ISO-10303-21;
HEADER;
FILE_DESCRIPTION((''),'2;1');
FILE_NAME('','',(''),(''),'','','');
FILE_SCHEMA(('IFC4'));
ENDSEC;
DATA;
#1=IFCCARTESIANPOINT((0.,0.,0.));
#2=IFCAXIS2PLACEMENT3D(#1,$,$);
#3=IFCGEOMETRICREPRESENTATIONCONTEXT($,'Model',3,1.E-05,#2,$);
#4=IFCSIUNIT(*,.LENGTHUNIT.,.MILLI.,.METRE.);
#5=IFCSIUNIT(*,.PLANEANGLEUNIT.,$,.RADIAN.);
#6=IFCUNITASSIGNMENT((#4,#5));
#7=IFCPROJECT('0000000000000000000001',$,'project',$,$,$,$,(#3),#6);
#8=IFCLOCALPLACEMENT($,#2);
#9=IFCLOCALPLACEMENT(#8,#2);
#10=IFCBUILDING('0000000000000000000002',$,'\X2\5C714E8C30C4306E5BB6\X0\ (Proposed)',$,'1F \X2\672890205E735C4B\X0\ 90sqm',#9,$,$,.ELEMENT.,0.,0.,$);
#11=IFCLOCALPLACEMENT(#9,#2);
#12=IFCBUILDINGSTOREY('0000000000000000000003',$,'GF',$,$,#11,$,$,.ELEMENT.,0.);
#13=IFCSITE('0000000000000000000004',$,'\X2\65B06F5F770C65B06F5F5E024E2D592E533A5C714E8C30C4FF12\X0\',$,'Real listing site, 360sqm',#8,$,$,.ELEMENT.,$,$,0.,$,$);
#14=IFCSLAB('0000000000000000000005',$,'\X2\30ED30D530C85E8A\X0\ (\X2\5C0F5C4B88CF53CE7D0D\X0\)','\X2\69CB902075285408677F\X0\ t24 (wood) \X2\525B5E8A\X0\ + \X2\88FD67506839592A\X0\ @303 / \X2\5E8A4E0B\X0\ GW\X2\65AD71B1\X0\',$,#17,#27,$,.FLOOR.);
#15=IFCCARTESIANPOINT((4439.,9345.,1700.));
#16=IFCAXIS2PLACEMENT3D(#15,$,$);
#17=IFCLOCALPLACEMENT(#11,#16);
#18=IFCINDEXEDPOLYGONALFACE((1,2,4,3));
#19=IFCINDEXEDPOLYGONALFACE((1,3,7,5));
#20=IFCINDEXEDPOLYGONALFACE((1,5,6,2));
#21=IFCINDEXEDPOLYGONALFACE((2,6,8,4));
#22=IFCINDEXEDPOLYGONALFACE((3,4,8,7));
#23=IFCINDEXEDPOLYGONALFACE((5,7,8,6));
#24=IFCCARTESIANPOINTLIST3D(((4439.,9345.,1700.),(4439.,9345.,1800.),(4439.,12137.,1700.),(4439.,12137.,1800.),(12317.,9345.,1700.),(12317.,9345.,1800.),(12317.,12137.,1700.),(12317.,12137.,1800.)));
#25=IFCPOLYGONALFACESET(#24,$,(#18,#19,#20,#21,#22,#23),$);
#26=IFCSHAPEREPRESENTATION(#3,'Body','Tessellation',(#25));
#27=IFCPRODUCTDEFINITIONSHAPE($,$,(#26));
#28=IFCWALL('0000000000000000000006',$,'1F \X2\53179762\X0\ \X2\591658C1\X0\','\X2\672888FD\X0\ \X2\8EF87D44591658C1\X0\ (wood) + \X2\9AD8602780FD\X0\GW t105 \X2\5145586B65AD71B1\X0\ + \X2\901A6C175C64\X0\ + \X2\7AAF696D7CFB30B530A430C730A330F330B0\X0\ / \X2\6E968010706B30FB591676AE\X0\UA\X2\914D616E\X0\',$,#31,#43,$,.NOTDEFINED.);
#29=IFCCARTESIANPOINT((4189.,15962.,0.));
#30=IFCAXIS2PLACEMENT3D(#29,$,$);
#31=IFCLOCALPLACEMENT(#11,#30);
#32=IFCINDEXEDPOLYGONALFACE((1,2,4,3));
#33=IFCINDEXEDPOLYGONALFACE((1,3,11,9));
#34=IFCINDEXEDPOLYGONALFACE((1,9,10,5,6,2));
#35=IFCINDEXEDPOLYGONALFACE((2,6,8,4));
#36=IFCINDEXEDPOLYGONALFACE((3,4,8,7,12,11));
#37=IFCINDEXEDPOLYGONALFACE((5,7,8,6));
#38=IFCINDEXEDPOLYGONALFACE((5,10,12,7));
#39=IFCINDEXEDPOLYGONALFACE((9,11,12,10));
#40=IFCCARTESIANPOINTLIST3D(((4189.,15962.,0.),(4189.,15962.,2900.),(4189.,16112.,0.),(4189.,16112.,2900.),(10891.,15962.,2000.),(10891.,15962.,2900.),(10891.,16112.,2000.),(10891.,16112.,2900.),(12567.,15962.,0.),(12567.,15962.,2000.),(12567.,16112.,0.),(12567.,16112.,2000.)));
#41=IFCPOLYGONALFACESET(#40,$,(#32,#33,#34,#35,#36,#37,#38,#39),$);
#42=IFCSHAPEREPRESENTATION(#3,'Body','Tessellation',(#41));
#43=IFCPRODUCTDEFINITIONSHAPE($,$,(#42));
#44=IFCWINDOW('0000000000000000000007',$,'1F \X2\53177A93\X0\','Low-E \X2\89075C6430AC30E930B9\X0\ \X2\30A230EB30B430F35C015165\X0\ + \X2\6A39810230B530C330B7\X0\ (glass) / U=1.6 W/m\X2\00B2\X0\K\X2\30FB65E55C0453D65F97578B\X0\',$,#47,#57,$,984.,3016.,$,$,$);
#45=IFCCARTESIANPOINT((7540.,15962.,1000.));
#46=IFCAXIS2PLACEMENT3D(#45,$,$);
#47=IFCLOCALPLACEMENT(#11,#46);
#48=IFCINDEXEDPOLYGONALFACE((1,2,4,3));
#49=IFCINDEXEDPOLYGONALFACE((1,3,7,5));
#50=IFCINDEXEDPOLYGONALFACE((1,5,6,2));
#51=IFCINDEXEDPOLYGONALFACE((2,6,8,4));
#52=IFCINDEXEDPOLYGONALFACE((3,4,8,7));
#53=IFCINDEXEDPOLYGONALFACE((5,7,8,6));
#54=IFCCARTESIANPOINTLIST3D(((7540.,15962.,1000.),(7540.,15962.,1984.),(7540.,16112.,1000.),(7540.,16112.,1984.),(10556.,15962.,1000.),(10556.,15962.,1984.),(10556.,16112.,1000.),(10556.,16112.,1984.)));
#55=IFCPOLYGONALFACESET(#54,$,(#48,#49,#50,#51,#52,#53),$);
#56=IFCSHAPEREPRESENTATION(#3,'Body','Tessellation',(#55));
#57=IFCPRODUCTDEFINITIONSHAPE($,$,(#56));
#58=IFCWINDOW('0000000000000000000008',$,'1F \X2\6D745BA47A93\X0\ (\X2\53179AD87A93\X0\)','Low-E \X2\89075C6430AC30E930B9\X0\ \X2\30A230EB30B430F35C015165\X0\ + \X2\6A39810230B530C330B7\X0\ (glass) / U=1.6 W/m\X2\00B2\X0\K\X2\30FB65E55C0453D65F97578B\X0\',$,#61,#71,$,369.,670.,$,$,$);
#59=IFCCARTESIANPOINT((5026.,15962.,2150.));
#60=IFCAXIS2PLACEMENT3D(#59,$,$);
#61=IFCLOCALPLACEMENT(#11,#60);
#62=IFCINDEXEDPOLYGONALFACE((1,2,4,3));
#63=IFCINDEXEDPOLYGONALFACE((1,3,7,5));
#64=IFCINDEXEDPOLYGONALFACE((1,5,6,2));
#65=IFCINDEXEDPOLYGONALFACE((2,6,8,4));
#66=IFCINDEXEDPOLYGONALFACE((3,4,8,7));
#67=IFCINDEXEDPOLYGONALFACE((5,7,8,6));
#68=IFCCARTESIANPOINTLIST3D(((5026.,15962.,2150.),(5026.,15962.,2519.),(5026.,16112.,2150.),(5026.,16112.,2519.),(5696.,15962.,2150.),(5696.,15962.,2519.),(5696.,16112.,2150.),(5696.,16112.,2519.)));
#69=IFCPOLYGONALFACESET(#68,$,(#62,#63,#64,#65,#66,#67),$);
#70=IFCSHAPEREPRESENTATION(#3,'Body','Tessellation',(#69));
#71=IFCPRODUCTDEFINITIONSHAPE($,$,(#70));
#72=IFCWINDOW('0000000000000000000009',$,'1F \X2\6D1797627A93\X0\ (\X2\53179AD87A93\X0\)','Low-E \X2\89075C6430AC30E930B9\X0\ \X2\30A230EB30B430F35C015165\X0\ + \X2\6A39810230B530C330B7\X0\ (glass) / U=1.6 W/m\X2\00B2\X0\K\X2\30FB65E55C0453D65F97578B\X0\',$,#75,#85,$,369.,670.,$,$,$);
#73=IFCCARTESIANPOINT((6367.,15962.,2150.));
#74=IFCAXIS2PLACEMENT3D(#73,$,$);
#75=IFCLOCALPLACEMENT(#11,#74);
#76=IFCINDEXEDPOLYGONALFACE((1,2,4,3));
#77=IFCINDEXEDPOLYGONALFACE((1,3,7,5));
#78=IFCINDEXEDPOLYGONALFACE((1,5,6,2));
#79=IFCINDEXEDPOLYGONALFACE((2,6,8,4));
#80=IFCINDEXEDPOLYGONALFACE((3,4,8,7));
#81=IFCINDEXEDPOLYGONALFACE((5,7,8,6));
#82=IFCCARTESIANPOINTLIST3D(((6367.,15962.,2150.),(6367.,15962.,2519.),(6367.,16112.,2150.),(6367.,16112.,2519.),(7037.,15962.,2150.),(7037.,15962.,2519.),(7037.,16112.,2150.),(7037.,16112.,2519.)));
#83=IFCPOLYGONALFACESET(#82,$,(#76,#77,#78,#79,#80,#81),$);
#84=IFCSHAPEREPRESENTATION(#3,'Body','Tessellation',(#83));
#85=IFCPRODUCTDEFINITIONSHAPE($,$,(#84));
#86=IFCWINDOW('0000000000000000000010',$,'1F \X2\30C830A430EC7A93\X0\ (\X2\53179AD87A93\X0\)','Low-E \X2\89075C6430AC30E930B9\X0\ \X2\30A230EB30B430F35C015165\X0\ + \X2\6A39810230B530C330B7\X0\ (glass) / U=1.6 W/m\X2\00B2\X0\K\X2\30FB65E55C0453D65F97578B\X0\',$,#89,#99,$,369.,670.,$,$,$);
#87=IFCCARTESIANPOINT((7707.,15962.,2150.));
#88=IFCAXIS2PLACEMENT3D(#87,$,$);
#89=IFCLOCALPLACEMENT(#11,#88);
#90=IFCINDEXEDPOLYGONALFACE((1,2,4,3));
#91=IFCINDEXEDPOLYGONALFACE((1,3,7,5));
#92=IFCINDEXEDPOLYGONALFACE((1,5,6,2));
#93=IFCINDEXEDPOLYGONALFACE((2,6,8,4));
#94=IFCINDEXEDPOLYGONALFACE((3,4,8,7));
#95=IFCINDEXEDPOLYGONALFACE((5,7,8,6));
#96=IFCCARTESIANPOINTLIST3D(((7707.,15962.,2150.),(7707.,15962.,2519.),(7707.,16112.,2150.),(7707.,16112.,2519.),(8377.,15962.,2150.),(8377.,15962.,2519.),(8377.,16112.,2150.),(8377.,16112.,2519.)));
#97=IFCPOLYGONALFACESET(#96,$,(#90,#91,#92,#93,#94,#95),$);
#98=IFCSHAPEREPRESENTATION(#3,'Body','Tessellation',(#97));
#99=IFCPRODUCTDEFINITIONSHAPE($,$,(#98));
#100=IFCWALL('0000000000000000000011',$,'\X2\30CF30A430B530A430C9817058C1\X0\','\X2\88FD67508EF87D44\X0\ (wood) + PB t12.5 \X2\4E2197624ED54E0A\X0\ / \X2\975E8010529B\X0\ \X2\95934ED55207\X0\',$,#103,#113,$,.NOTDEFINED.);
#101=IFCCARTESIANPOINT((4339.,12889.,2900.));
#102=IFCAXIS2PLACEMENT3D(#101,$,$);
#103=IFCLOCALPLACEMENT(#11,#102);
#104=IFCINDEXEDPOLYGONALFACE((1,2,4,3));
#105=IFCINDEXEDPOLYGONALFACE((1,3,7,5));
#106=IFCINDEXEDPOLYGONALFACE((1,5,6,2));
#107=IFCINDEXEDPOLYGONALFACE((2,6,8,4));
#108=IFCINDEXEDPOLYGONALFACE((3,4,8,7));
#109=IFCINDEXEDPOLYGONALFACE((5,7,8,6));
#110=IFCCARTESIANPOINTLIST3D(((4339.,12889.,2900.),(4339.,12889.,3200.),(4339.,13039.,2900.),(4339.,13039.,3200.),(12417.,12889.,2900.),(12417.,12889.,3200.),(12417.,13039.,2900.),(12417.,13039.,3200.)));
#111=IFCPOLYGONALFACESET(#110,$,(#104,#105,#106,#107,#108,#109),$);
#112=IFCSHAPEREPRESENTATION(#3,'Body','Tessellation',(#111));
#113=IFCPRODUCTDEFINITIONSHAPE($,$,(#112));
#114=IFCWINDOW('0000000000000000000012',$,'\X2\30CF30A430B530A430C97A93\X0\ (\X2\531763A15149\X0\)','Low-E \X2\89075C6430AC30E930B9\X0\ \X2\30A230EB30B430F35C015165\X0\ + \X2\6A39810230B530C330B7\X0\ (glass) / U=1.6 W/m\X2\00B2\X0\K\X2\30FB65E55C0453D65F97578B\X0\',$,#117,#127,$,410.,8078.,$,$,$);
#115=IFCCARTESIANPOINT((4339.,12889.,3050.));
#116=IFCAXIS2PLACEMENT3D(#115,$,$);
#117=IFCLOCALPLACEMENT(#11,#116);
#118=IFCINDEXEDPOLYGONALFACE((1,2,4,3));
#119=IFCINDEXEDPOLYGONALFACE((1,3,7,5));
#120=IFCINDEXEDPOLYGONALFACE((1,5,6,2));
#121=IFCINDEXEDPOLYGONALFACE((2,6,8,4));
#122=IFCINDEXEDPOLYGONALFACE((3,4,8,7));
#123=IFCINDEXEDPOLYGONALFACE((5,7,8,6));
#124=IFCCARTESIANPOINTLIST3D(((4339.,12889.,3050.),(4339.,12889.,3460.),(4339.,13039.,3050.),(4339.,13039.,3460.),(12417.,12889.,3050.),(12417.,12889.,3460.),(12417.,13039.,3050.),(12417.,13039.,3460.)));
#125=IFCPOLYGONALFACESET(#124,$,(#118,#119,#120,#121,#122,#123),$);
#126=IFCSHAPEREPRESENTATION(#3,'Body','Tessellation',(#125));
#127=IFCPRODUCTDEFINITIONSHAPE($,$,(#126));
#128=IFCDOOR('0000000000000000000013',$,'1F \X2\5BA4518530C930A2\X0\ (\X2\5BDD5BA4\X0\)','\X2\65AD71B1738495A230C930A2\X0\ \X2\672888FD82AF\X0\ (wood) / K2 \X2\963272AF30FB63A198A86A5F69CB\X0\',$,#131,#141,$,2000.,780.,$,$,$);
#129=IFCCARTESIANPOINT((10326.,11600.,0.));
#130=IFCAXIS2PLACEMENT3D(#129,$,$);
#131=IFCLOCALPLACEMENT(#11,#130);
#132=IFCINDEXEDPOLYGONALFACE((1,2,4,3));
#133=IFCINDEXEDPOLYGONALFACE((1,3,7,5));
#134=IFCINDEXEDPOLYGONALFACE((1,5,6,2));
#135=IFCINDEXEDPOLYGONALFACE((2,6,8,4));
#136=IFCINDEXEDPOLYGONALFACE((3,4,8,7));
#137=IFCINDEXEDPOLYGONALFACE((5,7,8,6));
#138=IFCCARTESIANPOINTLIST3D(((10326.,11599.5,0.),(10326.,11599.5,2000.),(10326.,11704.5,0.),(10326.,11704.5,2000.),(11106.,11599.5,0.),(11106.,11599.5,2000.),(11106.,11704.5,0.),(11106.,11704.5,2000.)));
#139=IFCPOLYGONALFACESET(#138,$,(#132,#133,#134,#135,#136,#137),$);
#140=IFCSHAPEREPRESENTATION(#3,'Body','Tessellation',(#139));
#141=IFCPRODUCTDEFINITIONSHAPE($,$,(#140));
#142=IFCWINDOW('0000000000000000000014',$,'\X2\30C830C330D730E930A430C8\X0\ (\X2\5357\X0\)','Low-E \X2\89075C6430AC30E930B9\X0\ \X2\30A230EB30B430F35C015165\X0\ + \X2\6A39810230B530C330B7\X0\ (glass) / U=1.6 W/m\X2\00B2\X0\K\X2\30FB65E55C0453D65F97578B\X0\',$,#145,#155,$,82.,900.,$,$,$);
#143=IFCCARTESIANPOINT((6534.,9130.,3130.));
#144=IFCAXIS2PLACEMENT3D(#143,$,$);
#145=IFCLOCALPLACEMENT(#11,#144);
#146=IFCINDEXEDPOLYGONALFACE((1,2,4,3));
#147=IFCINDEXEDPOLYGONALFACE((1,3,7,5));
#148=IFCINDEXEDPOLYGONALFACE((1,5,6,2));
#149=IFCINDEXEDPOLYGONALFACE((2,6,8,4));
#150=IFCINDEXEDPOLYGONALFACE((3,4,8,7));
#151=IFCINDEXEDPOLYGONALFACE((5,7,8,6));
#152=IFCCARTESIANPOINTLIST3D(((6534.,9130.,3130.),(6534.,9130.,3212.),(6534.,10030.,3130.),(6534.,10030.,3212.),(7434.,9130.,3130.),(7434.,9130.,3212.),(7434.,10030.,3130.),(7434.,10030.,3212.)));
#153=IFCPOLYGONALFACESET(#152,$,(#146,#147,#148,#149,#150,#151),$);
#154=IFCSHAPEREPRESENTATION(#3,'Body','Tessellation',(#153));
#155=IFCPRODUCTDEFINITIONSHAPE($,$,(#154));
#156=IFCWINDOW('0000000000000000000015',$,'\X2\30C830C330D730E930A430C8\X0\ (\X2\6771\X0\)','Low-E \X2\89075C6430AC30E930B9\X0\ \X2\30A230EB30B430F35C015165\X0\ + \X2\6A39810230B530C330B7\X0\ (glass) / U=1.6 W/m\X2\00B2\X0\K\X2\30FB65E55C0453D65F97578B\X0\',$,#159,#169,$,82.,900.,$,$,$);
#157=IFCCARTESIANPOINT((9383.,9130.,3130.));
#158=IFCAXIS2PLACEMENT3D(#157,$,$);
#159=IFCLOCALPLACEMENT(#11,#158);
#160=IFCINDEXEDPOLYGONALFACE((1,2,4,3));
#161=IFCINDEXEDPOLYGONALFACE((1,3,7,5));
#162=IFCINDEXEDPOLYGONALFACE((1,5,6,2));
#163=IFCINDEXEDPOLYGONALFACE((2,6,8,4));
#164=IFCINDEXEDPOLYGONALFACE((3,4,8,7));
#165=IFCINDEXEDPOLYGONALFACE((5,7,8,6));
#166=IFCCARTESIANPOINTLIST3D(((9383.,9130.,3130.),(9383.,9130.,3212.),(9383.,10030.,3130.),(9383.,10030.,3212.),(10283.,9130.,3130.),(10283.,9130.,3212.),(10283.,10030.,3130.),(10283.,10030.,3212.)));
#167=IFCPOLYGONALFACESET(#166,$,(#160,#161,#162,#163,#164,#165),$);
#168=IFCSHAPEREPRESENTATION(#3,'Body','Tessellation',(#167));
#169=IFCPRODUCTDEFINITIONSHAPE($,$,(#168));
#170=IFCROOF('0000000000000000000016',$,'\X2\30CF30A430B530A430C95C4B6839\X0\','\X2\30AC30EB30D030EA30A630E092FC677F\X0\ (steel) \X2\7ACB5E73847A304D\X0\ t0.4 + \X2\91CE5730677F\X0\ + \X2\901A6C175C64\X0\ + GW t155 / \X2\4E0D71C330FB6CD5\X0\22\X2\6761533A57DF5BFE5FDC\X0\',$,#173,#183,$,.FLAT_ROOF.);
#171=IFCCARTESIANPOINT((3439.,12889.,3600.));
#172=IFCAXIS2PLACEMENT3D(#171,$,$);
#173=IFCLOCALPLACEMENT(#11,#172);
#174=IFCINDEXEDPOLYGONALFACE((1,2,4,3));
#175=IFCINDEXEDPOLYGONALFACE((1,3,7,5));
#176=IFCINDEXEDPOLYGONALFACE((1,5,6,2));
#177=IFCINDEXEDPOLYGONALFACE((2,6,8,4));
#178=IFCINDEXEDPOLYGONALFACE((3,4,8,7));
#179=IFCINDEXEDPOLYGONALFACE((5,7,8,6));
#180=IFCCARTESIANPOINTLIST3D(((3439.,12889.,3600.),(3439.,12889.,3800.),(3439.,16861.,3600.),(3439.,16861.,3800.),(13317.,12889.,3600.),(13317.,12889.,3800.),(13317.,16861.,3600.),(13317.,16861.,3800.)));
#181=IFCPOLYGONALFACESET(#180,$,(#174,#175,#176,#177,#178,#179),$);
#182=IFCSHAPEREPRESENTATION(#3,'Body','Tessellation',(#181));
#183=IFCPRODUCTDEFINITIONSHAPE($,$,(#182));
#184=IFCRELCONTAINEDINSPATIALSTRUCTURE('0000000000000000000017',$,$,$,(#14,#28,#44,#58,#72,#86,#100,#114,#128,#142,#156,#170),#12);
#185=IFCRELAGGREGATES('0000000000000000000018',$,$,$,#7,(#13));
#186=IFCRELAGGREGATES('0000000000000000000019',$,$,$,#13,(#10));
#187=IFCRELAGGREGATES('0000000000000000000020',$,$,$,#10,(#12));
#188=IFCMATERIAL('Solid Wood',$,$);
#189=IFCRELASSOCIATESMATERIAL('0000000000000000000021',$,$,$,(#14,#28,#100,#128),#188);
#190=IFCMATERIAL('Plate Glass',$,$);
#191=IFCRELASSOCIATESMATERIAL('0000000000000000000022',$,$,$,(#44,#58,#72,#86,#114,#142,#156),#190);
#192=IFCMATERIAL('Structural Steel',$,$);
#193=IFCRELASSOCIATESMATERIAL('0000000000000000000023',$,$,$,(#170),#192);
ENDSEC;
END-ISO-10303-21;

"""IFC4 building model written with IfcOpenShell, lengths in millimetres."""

from ifc_helpers import new_model, si_unit, frame, frame_2d, origin, place, context, project, spatial, rectangle, extrude, material, element, fill, save


model = new_model("IFC4")

# Units and contexts
model_context = context("Model", 3, precision=1e-05, world=origin())
ifc_project = project(units=[si_unit("LENGTHUNIT", "METRE", prefix="MILLI"), si_unit("PLANEANGLEUNIT", "RADIAN")], contexts=[model_context])

# Site, building, storey
site_placement = place(None, origin())
site = spatial("IfcSite", under=ifc_project, at=site_placement, Name="新潟県新潟市中央区山二ツ２", ObjectType="Real listing site, 360sqm", CompositionType="ELEMENT", RefElevation=0.0)
building_placement = place(site_placement, origin())
building = spatial("IfcBuilding", under=site, at=building_placement, Name="山二ツの家 (Proposed)", ObjectType="1F 木造平屋 90sqm", CompositionType="ELEMENT", ElevationOfRefHeight=0.0, ElevationOfTerrain=0.0)
storey_placement = place(building_placement, origin())
storey = spatial("IfcBuildingStorey", under=building, at=storey_placement, Name="GF", CompositionType="ELEMENT", Elevation=0.0)

# Slab
ifc_material_1 = material(Name="Solid Wood")
slab_placement = place(storey_placement, frame((4439.0, 9345.0, 1700.0)))
element("IfcSlab", 1, at=slab_placement, inside=storey, material=ifc_material_1, Name="ロフト床 (小屋裏収納)", Description="構造用合板 t24 (wood) 剛床 + 製材根太 @303 / 床下 GW断熱", PredefinedType="FLOOR", context=model_context, shape_type="SweptSolid", body=[
    extrude(rectangle(XDim=7878.0, YDim=2792.0, at=frame_2d((3939.0, 1396.0))), frame((4439.0, 9345.0, 1700.0)), (0.0, 0.0, 1.0), 100.0),
])

# Wall, openings, windows
wall_1_placement = place(storey_placement, frame((4189.0, 15962.0, 0.0)))
wall_1 = element("IfcWall", 2, at=wall_1_placement, inside=storey, material=ifc_material_1, Name="1F 北面 外壁", Description="木製 軸組外壁 (wood) + 高性能GW t105 充填断熱 + 通気層 + 窯業系サイディング / 準耐火・外皮UA配慮", PredefinedType="NOTDEFINED", context=model_context, shape_type="SweptSolid", body=[
    extrude(rectangle(XDim=8378.0, YDim=150.0, at=frame_2d((4189.0, 75.0))), frame((4189.0, 15962.0, 0.0)), (0.0, 0.0, 1.0), 2900.0),
])
opening_1_placement = place(storey_placement, frame((7540.0, 15962.0, 1000.0)))
opening_1 = element("IfcOpeningElement", 3, at=opening_1_placement, cuts=wall_1, PredefinedType="NOTDEFINED", context=model_context, shape_type="SweptSolid", body=[
    extrude(rectangle(XDim=3016.0, YDim=150.0, at=frame_2d((1508.0, 75.0))), frame((7540.0, 15962.0, 1000.0)), (0.0, 0.0, 1.0), 984.0),
])
opening_2_placement = place(storey_placement, frame((5026.0, 15962.0, 2150.0)))
opening_2 = element("IfcOpeningElement", 4, at=opening_2_placement, cuts=wall_1, PredefinedType="NOTDEFINED", context=model_context, shape_type="SweptSolid", body=[
    extrude(rectangle(XDim=670.0, YDim=150.0, at=frame_2d((335.0, 75.0))), frame((5026.0, 15962.0, 2150.0)), (0.0, 0.0, 1.0), 369.0),
])
opening_3_placement = place(storey_placement, frame((6367.0, 15962.0, 2150.0)))
opening_3 = element("IfcOpeningElement", 5, at=opening_3_placement, cuts=wall_1, PredefinedType="NOTDEFINED", context=model_context, shape_type="SweptSolid", body=[
    extrude(rectangle(XDim=670.0, YDim=150.0, at=frame_2d((335.0, 75.0))), frame((6367.0, 15962.0, 2150.0)), (0.0, 0.0, 1.0), 369.0),
])
opening_4_placement = place(storey_placement, frame((7707.0, 15962.0, 2150.0)))
opening_4 = element("IfcOpeningElement", 6, at=opening_4_placement, cuts=wall_1, PredefinedType="NOTDEFINED", context=model_context, shape_type="SweptSolid", body=[
    extrude(rectangle(XDim=670.0, YDim=150.0, at=frame_2d((335.0, 75.0))), frame((7707.0, 15962.0, 2150.0)), (0.0, 0.0, 1.0), 369.0),
])
ifc_material_2 = material(Name="Plate Glass")
window_1_placement = place(storey_placement, frame((7540.0, 15962.0, 1000.0)))
window_1 = element("IfcWindow", 7, at=window_1_placement, inside=storey, material=ifc_material_2, Name="1F 北窓", Description="Low-E 複層ガラス アルゴン封入 + 樹脂サッシ (glass) / U=1.6 W/m²K・日射取得型", OverallHeight=984.0, OverallWidth=3016.0, context=model_context, shape_type="SweptSolid", body=[
    extrude(rectangle(XDim=3016.0, YDim=150.0, at=frame_2d((1508.0, 75.0))), frame((7540.0, 15962.0, 1000.0)), (0.0, 0.0, 1.0), 984.0),
])
fill(opening_1, window_1)
window_2_placement = place(storey_placement, frame((5026.0, 15962.0, 2150.0)))
window_2 = element("IfcWindow", 8, at=window_2_placement, inside=storey, material=ifc_material_2, Name="1F 浴室窓 (北高窓)", Description="Low-E 複層ガラス アルゴン封入 + 樹脂サッシ (glass) / U=1.6 W/m²K・日射取得型", OverallHeight=369.0, OverallWidth=670.0, context=model_context, shape_type="SweptSolid", body=[
    extrude(rectangle(XDim=670.0, YDim=150.0, at=frame_2d((335.0, 75.0))), frame((5026.0, 15962.0, 2150.0)), (0.0, 0.0, 1.0), 369.0),
])
fill(opening_2, window_2)
window_3_placement = place(storey_placement, frame((6367.0, 15962.0, 2150.0)))
window_3 = element("IfcWindow", 9, at=window_3_placement, inside=storey, material=ifc_material_2, Name="1F 洗面窓 (北高窓)", Description="Low-E 複層ガラス アルゴン封入 + 樹脂サッシ (glass) / U=1.6 W/m²K・日射取得型", OverallHeight=369.0, OverallWidth=670.0, context=model_context, shape_type="SweptSolid", body=[
    extrude(rectangle(XDim=670.0, YDim=150.0, at=frame_2d((335.0, 75.0))), frame((6367.0, 15962.0, 2150.0)), (0.0, 0.0, 1.0), 369.0),
])
fill(opening_3, window_3)
window_4_placement = place(storey_placement, frame((7707.0, 15962.0, 2150.0)))
window_4 = element("IfcWindow", 10, at=window_4_placement, inside=storey, material=ifc_material_2, Name="1F トイレ窓 (北高窓)", Description="Low-E 複層ガラス アルゴン封入 + 樹脂サッシ (glass) / U=1.6 W/m²K・日射取得型", OverallHeight=369.0, OverallWidth=670.0, context=model_context, shape_type="SweptSolid", body=[
    extrude(rectangle(XDim=670.0, YDim=150.0, at=frame_2d((335.0, 75.0))), frame((7707.0, 15962.0, 2150.0)), (0.0, 0.0, 1.0), 369.0),
])
fill(opening_4, window_4)

# Wall, opening, window
wall_2_placement = place(storey_placement, frame((4339.0, 12889.0, 2900.0)))
wall_2 = element("IfcWall", 11, at=wall_2_placement, inside=storey, material=ifc_material_1, Name="ハイサイド腰壁", Description="製材軸組 (wood) + PB t12.5 両面仕上 / 非耐力 間仕切", PredefinedType="NOTDEFINED", context=model_context, shape_type="SweptSolid", body=[
    extrude(rectangle(XDim=8078.0, YDim=150.0, at=frame_2d((4039.0, 75.0))), frame((4339.0, 12889.0, 2900.0)), (0.0, 0.0, 1.0), 700.0),
])
opening_5_placement = place(storey_placement, frame((4339.0, 12889.0, 3050.0)))
opening_5 = element("IfcOpeningElement", 12, at=opening_5_placement, cuts=wall_2, PredefinedType="NOTDEFINED", context=model_context, shape_type="SweptSolid", body=[
    extrude(rectangle(XDim=8078.0, YDim=150.0, at=frame_2d((4039.0, 75.0))), frame((4339.0, 12889.0, 3050.0)), (0.0, 0.0, 1.0), 410.0),
])
window_5_placement = place(storey_placement, frame((4339.0, 12889.0, 3050.0)))
window_5 = element("IfcWindow", 13, at=window_5_placement, inside=storey, material=ifc_material_2, Name="ハイサイド窓 (北採光)", Description="Low-E 複層ガラス アルゴン封入 + 樹脂サッシ (glass) / U=1.6 W/m²K・日射取得型", OverallHeight=410.0, OverallWidth=8078.0, context=model_context, shape_type="SweptSolid", body=[
    extrude(rectangle(XDim=8078.0, YDim=150.0, at=frame_2d((4039.0, 75.0))), frame((4339.0, 12889.0, 3050.0)), (0.0, 0.0, 1.0), 410.0),
])
fill(opening_5, window_5)

# Door
door_1_placement = place(storey_placement, frame((10326.0, 11600.0, 0.0)))
element("IfcDoor", 14, at=door_1_placement, inside=storey, material=ifc_material_1, Name="1F 室内ドア (寝室)", Description="断熱玄関ドア 木製芯 (wood) / K2 防犯・採風機構", OverallHeight=2000.0, OverallWidth=780.0, context=model_context, shape_type="SweptSolid", body=[
    extrude(rectangle(XDim=780.0, YDim=105.0, at=frame_2d((390.0, 52.0))), frame((10326.0, 11600.0, 0.0)), (0.0, 0.0, 1.0), 2000.0),
])

# Windows
window_6_placement = place(storey_placement, frame((6534.0, 9130.0, 3130.0)))
element("IfcWindow", 15, at=window_6_placement, inside=storey, material=ifc_material_2, Name="トップライト (南)", Description="Low-E 複層ガラス アルゴン封入 + 樹脂サッシ (glass) / U=1.6 W/m²K・日射取得型", OverallHeight=82.0, OverallWidth=900.0, context=model_context, shape_type="SweptSolid", body=[
    extrude(rectangle(XDim=900.0, YDim=900.0, at=frame_2d((450.0, 450.0))), frame((6534.0, 9130.0, 3130.0)), (0.0, 0.0, 1.0), 82.0),
])
window_7_placement = place(storey_placement, frame((9383.0, 9130.0, 3130.0)))
element("IfcWindow", 16, at=window_7_placement, inside=storey, material=ifc_material_2, Name="トップライト (東)", Description="Low-E 複層ガラス アルゴン封入 + 樹脂サッシ (glass) / U=1.6 W/m²K・日射取得型", OverallHeight=82.0, OverallWidth=900.0, context=model_context, shape_type="SweptSolid", body=[
    extrude(rectangle(XDim=900.0, YDim=900.0, at=frame_2d((450.0, 450.0))), frame((9383.0, 9130.0, 3130.0)), (0.0, 0.0, 1.0), 82.0),
])

# Roof
ifc_material_3 = material(Name="Structural Steel")
roof_placement = place(storey_placement, frame((3439.0, 12889.0, 3600.0)))
element("IfcRoof", 17, at=roof_placement, inside=storey, material=ifc_material_3, Name="ハイサイド屋根", Description="ガルバリウム鋼板 (steel) 立平葺き t0.4 + 野地板 + 通気層 + GW t155 / 不燃・法22条区域対応", PredefinedType="FLAT_ROOF", context=model_context, shape_type="SweptSolid", body=[
    extrude(rectangle(XDim=9878.0, YDim=3972.0, at=frame_2d((4939.0, 1986.0))), frame((3439.0, 12889.0, 3600.0)), (0.0, 0.0, 1.0), 200.0),
])

save(model, "model.ifc")
